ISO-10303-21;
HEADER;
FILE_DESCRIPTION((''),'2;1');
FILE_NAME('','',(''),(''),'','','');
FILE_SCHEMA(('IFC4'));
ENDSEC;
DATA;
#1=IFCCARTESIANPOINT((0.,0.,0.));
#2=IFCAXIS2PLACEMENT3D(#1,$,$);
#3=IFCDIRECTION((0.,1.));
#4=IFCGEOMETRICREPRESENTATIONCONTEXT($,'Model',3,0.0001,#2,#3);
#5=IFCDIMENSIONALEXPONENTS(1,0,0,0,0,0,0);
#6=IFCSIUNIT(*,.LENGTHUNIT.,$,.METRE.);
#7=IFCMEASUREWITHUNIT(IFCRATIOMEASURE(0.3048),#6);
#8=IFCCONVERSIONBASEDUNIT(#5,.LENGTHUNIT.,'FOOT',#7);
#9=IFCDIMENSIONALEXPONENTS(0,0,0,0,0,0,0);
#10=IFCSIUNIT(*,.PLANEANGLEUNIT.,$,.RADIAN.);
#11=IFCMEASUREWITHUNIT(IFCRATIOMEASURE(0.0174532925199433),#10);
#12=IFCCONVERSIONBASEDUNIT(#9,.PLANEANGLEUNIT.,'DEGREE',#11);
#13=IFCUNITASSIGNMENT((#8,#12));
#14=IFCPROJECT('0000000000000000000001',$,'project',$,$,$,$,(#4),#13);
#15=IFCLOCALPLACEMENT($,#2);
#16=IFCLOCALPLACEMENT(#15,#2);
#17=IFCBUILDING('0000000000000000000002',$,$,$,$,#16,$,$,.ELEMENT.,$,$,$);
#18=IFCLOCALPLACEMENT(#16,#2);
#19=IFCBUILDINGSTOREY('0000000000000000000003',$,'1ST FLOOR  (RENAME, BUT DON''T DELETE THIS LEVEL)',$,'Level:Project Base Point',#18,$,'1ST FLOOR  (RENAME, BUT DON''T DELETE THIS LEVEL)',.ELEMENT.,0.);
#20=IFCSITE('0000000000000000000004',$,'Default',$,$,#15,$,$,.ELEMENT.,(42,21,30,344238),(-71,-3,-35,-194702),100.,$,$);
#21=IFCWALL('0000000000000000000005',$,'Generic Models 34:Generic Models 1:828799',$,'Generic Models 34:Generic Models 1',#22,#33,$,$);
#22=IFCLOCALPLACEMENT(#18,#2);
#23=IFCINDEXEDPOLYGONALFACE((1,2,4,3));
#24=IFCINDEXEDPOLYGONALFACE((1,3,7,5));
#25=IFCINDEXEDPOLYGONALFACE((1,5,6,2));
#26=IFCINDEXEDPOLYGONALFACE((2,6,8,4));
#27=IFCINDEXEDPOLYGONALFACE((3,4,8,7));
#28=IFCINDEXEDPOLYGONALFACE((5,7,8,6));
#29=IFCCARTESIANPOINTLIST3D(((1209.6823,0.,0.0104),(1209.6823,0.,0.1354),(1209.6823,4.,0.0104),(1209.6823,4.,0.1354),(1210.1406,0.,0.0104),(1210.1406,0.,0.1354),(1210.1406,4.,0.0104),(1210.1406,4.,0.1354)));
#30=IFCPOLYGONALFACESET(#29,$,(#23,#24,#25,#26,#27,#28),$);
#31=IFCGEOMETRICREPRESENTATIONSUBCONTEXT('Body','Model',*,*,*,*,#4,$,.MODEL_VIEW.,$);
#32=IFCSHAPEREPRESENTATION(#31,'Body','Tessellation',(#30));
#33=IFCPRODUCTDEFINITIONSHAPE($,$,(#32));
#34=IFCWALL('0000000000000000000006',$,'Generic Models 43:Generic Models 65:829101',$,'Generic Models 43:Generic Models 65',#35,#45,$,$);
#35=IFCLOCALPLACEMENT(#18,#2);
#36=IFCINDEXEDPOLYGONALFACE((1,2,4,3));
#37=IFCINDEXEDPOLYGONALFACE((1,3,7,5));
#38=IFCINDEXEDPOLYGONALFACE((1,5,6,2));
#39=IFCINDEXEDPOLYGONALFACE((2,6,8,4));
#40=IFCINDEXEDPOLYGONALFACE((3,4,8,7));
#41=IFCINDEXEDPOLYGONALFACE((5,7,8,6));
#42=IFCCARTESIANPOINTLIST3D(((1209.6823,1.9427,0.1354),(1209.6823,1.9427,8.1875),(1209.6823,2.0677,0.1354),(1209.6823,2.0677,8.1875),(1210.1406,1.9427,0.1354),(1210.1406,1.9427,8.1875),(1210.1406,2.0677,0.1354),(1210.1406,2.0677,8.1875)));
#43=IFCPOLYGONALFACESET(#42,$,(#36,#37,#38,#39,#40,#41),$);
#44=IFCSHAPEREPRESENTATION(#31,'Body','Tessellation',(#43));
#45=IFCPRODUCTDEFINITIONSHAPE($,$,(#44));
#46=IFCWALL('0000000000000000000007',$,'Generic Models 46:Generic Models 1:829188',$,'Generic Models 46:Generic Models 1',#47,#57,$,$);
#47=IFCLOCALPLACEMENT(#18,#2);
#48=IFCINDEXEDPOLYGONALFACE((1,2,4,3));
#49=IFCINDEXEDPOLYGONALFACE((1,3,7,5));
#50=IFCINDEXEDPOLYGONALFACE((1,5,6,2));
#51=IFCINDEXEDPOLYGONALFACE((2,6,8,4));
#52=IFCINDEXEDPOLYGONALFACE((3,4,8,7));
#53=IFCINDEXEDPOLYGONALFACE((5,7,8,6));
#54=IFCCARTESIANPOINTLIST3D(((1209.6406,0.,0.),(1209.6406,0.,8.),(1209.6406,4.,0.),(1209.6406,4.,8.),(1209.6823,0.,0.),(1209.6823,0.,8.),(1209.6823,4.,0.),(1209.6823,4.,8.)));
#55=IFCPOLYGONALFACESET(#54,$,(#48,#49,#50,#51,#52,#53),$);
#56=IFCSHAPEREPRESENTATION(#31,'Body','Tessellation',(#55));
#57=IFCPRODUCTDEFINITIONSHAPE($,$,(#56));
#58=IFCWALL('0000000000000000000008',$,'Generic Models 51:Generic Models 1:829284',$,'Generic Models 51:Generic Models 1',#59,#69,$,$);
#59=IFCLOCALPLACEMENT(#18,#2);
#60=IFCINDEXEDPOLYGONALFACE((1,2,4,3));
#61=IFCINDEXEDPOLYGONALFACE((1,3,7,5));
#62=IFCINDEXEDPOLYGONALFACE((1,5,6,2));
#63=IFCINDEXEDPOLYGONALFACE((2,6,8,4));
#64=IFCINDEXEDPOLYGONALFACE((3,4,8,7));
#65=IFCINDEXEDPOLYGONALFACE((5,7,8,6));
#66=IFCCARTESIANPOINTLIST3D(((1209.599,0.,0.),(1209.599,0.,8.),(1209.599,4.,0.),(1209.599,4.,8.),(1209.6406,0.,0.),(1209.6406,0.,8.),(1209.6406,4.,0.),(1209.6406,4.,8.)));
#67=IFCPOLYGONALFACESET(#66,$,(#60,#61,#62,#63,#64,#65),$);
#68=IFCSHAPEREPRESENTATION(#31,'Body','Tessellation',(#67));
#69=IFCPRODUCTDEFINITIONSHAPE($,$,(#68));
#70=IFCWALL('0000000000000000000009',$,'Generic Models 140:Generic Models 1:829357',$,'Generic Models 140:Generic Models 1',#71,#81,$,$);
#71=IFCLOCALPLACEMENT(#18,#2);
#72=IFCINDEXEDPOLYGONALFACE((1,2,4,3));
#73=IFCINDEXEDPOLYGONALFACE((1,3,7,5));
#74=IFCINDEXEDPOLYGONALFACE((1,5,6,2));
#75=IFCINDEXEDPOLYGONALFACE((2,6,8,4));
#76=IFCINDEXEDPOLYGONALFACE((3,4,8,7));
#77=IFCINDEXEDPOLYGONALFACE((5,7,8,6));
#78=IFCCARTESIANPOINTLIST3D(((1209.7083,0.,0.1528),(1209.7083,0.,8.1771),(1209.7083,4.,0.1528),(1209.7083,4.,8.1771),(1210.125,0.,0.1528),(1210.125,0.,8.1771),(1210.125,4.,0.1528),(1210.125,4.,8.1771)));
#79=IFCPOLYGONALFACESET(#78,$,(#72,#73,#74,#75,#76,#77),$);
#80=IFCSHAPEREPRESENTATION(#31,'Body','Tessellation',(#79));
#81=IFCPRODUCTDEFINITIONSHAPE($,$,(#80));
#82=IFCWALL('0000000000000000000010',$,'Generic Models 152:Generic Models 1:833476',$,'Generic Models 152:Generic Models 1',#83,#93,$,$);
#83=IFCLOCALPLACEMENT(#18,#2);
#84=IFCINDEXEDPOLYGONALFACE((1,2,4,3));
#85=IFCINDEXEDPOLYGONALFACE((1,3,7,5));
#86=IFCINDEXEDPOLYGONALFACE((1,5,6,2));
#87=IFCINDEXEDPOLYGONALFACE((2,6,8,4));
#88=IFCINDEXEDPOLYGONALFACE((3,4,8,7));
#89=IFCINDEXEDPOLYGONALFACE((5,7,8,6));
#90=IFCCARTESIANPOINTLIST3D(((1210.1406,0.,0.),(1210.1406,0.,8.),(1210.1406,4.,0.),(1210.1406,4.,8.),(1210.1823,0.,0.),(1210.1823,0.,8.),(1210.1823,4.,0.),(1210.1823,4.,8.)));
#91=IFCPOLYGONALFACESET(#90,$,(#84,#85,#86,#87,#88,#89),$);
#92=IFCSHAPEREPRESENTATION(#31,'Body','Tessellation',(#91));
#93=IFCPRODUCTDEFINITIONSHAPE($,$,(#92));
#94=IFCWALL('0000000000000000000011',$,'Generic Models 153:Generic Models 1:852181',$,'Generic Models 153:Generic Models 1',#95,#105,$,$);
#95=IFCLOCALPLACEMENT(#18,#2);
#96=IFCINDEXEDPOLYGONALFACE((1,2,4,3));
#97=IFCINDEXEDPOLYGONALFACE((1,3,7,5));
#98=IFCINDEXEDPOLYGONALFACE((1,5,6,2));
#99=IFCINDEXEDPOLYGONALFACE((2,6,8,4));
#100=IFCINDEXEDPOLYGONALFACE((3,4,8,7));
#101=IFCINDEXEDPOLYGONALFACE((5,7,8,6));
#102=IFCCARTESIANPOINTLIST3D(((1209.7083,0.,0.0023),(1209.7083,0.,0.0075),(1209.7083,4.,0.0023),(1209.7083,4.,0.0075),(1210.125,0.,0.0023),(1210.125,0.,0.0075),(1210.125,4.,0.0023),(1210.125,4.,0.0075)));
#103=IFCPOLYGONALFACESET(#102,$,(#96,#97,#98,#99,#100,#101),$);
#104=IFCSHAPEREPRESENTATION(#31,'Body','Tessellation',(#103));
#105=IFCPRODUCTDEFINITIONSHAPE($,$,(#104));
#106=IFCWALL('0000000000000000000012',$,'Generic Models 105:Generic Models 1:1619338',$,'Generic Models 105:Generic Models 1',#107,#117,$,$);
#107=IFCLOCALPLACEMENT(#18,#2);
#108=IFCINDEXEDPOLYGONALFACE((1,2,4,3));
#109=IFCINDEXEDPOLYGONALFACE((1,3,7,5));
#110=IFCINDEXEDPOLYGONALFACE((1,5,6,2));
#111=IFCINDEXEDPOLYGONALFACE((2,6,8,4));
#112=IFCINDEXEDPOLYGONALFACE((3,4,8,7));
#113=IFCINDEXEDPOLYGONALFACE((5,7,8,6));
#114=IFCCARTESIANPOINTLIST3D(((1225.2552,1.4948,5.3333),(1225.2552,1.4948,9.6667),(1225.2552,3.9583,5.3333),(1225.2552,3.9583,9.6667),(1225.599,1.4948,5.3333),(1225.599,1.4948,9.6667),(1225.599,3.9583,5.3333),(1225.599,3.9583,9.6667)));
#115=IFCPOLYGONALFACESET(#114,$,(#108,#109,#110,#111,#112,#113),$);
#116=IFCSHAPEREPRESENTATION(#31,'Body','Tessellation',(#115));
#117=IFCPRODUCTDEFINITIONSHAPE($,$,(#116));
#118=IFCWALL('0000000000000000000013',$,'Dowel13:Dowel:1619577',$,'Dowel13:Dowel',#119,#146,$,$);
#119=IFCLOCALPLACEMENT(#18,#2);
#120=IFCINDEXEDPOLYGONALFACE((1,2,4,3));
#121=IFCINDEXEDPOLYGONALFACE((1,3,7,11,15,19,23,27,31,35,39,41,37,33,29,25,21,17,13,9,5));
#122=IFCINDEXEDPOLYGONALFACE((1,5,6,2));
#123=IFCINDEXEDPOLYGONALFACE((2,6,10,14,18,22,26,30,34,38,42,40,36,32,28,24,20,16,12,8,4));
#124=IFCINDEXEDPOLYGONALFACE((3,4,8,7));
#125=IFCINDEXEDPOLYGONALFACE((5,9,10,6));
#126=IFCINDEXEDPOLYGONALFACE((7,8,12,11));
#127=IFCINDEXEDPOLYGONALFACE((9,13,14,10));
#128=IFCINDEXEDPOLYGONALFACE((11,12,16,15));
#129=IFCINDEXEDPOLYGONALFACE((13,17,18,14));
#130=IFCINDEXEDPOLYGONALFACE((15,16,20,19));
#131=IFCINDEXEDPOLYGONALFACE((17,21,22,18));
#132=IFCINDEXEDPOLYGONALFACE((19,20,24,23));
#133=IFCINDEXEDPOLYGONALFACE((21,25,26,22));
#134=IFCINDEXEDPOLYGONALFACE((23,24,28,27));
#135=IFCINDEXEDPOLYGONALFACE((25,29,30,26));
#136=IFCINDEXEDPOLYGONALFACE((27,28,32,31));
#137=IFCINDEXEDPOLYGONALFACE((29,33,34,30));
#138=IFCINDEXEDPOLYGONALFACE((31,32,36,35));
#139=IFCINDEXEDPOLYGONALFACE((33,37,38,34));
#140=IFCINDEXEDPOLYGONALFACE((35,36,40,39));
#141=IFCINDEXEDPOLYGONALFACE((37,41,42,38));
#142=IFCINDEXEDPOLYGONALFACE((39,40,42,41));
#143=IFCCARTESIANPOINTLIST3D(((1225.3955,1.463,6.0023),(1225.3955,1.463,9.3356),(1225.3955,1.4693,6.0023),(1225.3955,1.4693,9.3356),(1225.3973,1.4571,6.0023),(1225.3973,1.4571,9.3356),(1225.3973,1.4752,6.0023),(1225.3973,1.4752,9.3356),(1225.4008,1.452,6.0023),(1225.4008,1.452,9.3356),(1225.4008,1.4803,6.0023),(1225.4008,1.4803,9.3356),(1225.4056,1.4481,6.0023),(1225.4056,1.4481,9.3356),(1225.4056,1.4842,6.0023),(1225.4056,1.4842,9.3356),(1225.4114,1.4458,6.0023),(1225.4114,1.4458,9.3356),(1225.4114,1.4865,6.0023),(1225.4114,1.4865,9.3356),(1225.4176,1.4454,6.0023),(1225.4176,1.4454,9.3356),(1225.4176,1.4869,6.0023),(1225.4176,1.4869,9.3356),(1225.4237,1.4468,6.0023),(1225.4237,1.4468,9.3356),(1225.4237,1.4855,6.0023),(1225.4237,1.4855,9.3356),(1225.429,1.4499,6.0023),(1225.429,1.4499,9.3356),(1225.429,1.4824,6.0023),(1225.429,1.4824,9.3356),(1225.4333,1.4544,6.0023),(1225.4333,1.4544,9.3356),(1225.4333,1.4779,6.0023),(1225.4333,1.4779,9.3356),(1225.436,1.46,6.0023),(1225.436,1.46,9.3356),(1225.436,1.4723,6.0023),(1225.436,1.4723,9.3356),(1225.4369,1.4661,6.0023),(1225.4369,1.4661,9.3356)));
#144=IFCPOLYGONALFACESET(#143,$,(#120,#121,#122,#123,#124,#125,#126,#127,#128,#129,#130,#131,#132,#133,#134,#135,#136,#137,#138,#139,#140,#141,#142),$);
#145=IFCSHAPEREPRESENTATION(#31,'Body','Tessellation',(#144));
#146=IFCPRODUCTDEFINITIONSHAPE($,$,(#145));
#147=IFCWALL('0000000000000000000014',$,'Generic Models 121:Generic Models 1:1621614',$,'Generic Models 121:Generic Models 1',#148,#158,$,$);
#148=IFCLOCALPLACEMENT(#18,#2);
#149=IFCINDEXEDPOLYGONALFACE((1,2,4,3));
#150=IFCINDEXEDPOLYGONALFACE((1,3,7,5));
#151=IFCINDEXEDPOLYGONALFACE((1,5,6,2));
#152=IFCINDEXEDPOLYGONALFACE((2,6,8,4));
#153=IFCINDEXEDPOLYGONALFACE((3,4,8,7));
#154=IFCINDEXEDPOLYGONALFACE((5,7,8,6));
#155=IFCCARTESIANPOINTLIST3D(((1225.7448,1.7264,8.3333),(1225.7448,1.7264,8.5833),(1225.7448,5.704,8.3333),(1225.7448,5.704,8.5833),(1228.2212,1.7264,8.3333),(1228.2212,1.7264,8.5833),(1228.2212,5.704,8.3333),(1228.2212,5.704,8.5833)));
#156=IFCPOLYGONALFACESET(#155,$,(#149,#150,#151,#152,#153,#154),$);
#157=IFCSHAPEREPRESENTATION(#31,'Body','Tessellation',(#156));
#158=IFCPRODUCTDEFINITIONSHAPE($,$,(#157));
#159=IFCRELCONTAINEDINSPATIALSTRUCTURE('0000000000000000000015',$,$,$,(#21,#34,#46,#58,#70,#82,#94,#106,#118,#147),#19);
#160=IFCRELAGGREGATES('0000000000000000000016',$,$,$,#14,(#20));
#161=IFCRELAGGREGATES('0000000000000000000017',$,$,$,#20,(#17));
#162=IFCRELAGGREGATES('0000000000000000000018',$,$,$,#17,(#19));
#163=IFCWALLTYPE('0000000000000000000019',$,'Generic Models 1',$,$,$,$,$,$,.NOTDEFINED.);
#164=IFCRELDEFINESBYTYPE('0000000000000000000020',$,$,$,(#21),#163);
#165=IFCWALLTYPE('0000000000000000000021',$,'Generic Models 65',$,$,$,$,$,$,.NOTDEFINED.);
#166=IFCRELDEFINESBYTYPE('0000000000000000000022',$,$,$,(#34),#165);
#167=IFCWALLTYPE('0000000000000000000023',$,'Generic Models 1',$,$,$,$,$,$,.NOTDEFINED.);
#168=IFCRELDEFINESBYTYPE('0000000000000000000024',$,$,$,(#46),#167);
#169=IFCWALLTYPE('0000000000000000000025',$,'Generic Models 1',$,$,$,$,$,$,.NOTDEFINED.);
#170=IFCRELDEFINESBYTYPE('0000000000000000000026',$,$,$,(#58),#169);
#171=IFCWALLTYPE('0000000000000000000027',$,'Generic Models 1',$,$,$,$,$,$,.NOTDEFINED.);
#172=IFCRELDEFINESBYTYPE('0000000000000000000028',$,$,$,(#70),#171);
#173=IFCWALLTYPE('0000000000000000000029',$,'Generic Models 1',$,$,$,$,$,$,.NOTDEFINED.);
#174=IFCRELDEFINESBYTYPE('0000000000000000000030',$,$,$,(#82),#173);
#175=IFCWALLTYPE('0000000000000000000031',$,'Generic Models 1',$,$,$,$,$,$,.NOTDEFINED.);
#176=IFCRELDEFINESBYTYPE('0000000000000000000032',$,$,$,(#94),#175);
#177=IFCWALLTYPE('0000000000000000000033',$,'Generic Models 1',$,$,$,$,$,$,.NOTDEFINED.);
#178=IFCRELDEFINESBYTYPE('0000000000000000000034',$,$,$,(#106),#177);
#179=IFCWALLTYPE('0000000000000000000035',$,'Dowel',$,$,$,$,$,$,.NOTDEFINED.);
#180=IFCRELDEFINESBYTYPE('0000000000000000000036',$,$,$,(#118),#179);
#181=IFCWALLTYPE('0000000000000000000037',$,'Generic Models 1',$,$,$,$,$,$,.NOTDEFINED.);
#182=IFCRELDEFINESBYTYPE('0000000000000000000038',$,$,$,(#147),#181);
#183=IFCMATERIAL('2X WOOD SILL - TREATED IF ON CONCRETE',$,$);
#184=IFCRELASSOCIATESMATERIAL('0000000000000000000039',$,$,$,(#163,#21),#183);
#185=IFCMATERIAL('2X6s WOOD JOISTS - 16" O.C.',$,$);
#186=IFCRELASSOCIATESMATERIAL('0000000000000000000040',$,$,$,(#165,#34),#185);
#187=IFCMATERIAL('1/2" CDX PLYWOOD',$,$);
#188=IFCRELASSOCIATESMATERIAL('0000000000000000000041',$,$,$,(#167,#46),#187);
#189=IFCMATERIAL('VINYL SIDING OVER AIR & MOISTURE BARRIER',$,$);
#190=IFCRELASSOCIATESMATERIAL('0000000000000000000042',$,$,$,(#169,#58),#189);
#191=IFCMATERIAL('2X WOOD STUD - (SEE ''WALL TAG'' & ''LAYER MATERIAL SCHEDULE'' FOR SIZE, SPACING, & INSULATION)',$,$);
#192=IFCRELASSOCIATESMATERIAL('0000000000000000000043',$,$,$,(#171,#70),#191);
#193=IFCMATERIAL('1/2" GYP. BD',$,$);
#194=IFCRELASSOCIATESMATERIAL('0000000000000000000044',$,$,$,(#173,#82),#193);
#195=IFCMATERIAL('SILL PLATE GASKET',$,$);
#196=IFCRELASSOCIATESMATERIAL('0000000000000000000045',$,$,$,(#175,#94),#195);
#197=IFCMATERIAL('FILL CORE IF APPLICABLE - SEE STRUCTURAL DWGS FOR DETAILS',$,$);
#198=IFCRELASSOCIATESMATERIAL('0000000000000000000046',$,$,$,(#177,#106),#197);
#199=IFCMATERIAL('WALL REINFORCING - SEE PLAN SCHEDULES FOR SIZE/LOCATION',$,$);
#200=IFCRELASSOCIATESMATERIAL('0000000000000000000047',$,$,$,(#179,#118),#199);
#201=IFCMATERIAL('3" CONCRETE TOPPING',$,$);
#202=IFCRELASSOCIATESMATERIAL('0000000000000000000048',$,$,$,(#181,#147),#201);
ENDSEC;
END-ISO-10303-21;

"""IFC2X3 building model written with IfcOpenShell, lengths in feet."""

from ifc_helpers import new_model, entity, si_unit, converted_unit, direction, frame, frame_2d, origin, origin_2d_with_axis, place, context, subcontext, project, spatial, rectangle, circle, extrude, material, type_object, element, save


model = new_model("IFC2X3")

# Units and contexts
model_context = context("Model", 3, precision=0.0001, world=origin(), true_north=direction((0.0, 1.0)))
body_context = subcontext(model_context, "Body", "Model", "MODEL_VIEW")
ifc_project = project(units=[converted_unit("LENGTHUNIT", "FOOT", entity("IfcRatioMeasure", 0.3048), si_unit("LENGTHUNIT", "METRE"), dimensions=[1, 0, 0, 0, 0, 0, 0]), converted_unit("PLANEANGLEUNIT", "DEGREE", entity("IfcRatioMeasure", 0.0174532925199433), si_unit("PLANEANGLEUNIT", "RADIAN"), dimensions=[0, 0, 0, 0, 0, 0, 0])], contexts=[model_context])

# Site, building, storey
site_placement = place(None, origin())
site = spatial("IfcSite", under=ifc_project, at=site_placement, Name="Default", CompositionType="ELEMENT", RefLatitude=(42, 21, 30, 344238), RefLongitude=(-71, -3, -35, -194702), RefElevation=100.0)
building_placement = place(site_placement, origin())
building = spatial("IfcBuilding", under=site, at=building_placement, CompositionType="ELEMENT")
storey_placement = place(building_placement, origin())
storey = spatial("IfcBuildingStorey", under=building, at=storey_placement, Name="1ST FLOOR  (RENAME, BUT DON'T DELETE THIS LEVEL)", ObjectType="Level:Project Base Point", LongName="1ST FLOOR  (RENAME, BUT DON'T DELETE THIS LEVEL)", CompositionType="ELEMENT", Elevation=0.0)

# Walls
ifc_material_1 = material(Name="2X WOOD SILL - TREATED IF ON CONCRETE")
wall_type_1 = type_object("IfcWallType", Name="Generic Models 1", PredefinedType="NOTDEFINED", material=ifc_material_1)
wall_1_placement = place(storey_placement, frame((1209.6823, 0.0, 0.0104), z_axis=(0.0, 0.0, 1.0), x_axis=(0.0, 1.0, 0.0)))
element("IfcWall", 1, at=wall_1_placement, inside=storey, type_object=wall_type_1, material=ifc_material_1, Name="Generic Models 34:Generic Models 1:828799", ObjectType="Generic Models 34:Generic Models 1", context=body_context, shape_type="SweptSolid", body=[
    extrude(rectangle(XDim=4.0, YDim=0.4583, at=frame_2d((0.0, 0.0), x_axis=(1.0, 0.0))), frame((2.0, -0.2292, 0.0)), (0.0, 0.0, 1.0), 0.125),
])
ifc_material_2 = material(Name="2X6s WOOD JOISTS - 16\" O.C.")
wall_type_2 = type_object("IfcWallType", Name="Generic Models 65", PredefinedType="NOTDEFINED", material=ifc_material_2)
wall_2_placement = place(storey_placement, frame((1209.6823, 1.9427, 0.1354)))
element("IfcWall", 2, at=wall_2_placement, inside=storey, type_object=wall_type_2, material=ifc_material_2, Name="Generic Models 43:Generic Models 65:829101", ObjectType="Generic Models 43:Generic Models 65", context=body_context, shape_type="SweptSolid", body=[
    extrude(rectangle(XDim=0.125, YDim=0.4583, at=frame_2d((0.0, 0.0), x_axis=(1.0, 0.0))), frame((0.2292, 0.0625, 0.0), z_axis=(0.0, 0.0, 1.0), x_axis=(0.0, 1.0, 0.0)), (0.0, 0.0, 1.0), 8.0521),
])
ifc_material_3 = material(Name="1/2\" CDX PLYWOOD")
wall_type_3 = type_object("IfcWallType", Name="Generic Models 1", PredefinedType="NOTDEFINED", material=ifc_material_3)
wall_3_placement = place(storey_placement, frame((1209.6406, 0.0, 0.0), z_axis=(0.0, 0.0, 1.0), x_axis=(0.0, 1.0, 0.0)))
element("IfcWall", 3, at=wall_3_placement, inside=storey, type_object=wall_type_3, material=ifc_material_3, Name="Generic Models 46:Generic Models 1:829188", ObjectType="Generic Models 46:Generic Models 1", context=body_context, shape_type="SweptSolid", body=[
    extrude(rectangle(XDim=4.0, YDim=0.0417, at=frame_2d((0.0, 0.0), x_axis=(1.0, 0.0))), frame((2.0, -0.0208, 0.0), z_axis=(0.0, 0.0, 1.0), x_axis=(-1.0, 0.0, 0.0)), (0.0, 0.0, 1.0), 8.0),
])
ifc_material_4 = material(Name="VINYL SIDING OVER AIR & MOISTURE BARRIER")
wall_type_4 = type_object("IfcWallType", Name="Generic Models 1", PredefinedType="NOTDEFINED", material=ifc_material_4)
wall_4_placement = place(storey_placement, frame((1209.599, 0.0, 0.0), z_axis=(0.0, 0.0, 1.0), x_axis=(0.0, 1.0, 0.0)))
element("IfcWall", 4, at=wall_4_placement, inside=storey, type_object=wall_type_4, material=ifc_material_4, Name="Generic Models 51:Generic Models 1:829284", ObjectType="Generic Models 51:Generic Models 1", context=body_context, shape_type="SweptSolid", body=[
    extrude(rectangle(XDim=4.0, YDim=0.0417, at=frame_2d((0.0, 0.0), x_axis=(1.0, 0.0))), frame((2.0, -0.0208, 0.0), z_axis=(0.0, 0.0, 1.0), x_axis=(-1.0, 0.0, 0.0)), (0.0, 0.0, 1.0), 8.0),
])
ifc_material_5 = material(Name="2X WOOD STUD - (SEE 'WALL TAG' & 'LAYER MATERIAL SCHEDULE' FOR SIZE, SPACING, & INSULATION)")
wall_type_5 = type_object("IfcWallType", Name="Generic Models 1", PredefinedType="NOTDEFINED", material=ifc_material_5)
wall_5_placement = place(storey_placement, frame((1209.7083, 0.0, 0.1528), z_axis=(0.0, 0.0, 1.0), x_axis=(0.0, 1.0, 0.0)))
element("IfcWall", 5, at=wall_5_placement, inside=storey, type_object=wall_type_5, material=ifc_material_5, Name="Generic Models 140:Generic Models 1:829357", ObjectType="Generic Models 140:Generic Models 1", context=body_context, shape_type="SweptSolid", body=[
    extrude(rectangle(XDim=4.0, YDim=0.4167, at=frame_2d((0.0, 0.0), x_axis=(1.0, 0.0))), frame((2.0, -0.2083, 0.0), z_axis=(0.0, 0.0, 1.0), x_axis=(-1.0, 0.0, 0.0)), (0.0, 0.0, 1.0), 8.0242),
])
ifc_material_6 = material(Name="1/2\" GYP. BD")
wall_type_6 = type_object("IfcWallType", Name="Generic Models 1", PredefinedType="NOTDEFINED", material=ifc_material_6)
wall_6_placement = place(storey_placement, frame((1210.1406, 0.0, 0.0), z_axis=(0.0, 0.0, 1.0), x_axis=(0.0, 1.0, 0.0)))
element("IfcWall", 6, at=wall_6_placement, inside=storey, type_object=wall_type_6, material=ifc_material_6, Name="Generic Models 152:Generic Models 1:833476", ObjectType="Generic Models 152:Generic Models 1", context=body_context, shape_type="SweptSolid", body=[
    extrude(rectangle(XDim=4.0, YDim=0.0417, at=frame_2d((0.0, 0.0), x_axis=(1.0, 0.0))), frame((2.0, -0.0208, 0.0)), (0.0, 0.0, 1.0), 8.0),
])
ifc_material_7 = material(Name="SILL PLATE GASKET")
wall_type_7 = type_object("IfcWallType", Name="Generic Models 1", PredefinedType="NOTDEFINED", material=ifc_material_7)
wall_7_placement = place(storey_placement, frame((1209.7083, 0.0, 0.0023), z_axis=(0.0, 0.0, 1.0), x_axis=(0.0, 1.0, 0.0)))
element("IfcWall", 7, at=wall_7_placement, inside=storey, type_object=wall_type_7, material=ifc_material_7, Name="Generic Models 153:Generic Models 1:852181", ObjectType="Generic Models 153:Generic Models 1", context=body_context, shape_type="SweptSolid", body=[
    extrude(rectangle(XDim=4.0, YDim=0.4167, at=origin_2d_with_axis()), frame((2.0, -0.2083, 0.0), z_axis=(0.0, 0.0, 1.0), x_axis=(-1.0, 0.0, 0.0)), (0.0, 0.0, 1.0), 0.0052),
])
ifc_material_8 = material(Name="FILL CORE IF APPLICABLE - SEE STRUCTURAL DWGS FOR DETAILS")
wall_type_8 = type_object("IfcWallType", Name="Generic Models 1", PredefinedType="NOTDEFINED", material=ifc_material_8)
wall_8_placement = place(storey_placement, frame((1225.2552, 1.4948, 5.3333), z_axis=(0.0, 0.0, 1.0), x_axis=(0.0, 1.0, 0.0)))
element("IfcWall", 8, at=wall_8_placement, inside=storey, type_object=wall_type_8, material=ifc_material_8, Name="Generic Models 105:Generic Models 1:1619338", ObjectType="Generic Models 105:Generic Models 1", context=body_context, shape_type="SweptSolid", body=[
    extrude(rectangle(XDim=2.4635, YDim=0.3438, at=frame_2d((0.0, 0.0), x_axis=(1.0, 0.0))), frame((1.2318, -0.1719, 0.0)), (0.0, 0.0, 1.0), 4.3333),
])

# Wall
ifc_material_9 = material(Name="WALL REINFORCING - SEE PLAN SCHEDULES FOR SIZE/LOCATION")
wall_type_9 = type_object("IfcWallType", Name="Dowel", PredefinedType="NOTDEFINED", material=ifc_material_9)
wall_9_placement = place(storey_placement, frame((1225.3952, 1.4453, 6.0023), z_axis=(0.0, 0.0, 1.0), x_axis=(0.0, 1.0, 0.0)))
element("IfcWall", 9, at=wall_9_placement, inside=storey, type_object=wall_type_9, material=ifc_material_9, Name="Dowel13:Dowel:1619577", ObjectType="Dowel13:Dowel", context=body_context, shape_type="SweptSolid", body=[
    extrude(circle(Radius=0.0208, at=origin_2d_with_axis()), frame((0.0208, -0.0208, 0.0), z_axis=(0.0, 0.0, 1.0), x_axis=(0.0, -1.0, 0.0)), (0.0, 0.0, 1.0), 3.3333),
])

# Wall
ifc_material_10 = material(Name="3\" CONCRETE TOPPING")
wall_type_10 = type_object("IfcWallType", Name="Generic Models 1", PredefinedType="NOTDEFINED", material=ifc_material_10)
wall_10_placement = place(storey_placement, frame((1225.7448, 1.7264, 8.3333), z_axis=(0.0, 0.0, 1.0), x_axis=(0.0, 1.0, 0.0)))
element("IfcWall", 10, at=wall_10_placement, inside=storey, type_object=wall_type_10, material=ifc_material_10, Name="Generic Models 121:Generic Models 1:1621614", ObjectType="Generic Models 121:Generic Models 1", context=body_context, shape_type="SweptSolid", body=[
    extrude(rectangle(XDim=3.9776, YDim=2.4764, at=frame_2d((0.0, 0.0), x_axis=(1.0, 0.0))), frame((1.9888, -1.2382, 0.0)), (0.0, 0.0, 1.0), 0.25),
])

save(model, "model.ifc")
